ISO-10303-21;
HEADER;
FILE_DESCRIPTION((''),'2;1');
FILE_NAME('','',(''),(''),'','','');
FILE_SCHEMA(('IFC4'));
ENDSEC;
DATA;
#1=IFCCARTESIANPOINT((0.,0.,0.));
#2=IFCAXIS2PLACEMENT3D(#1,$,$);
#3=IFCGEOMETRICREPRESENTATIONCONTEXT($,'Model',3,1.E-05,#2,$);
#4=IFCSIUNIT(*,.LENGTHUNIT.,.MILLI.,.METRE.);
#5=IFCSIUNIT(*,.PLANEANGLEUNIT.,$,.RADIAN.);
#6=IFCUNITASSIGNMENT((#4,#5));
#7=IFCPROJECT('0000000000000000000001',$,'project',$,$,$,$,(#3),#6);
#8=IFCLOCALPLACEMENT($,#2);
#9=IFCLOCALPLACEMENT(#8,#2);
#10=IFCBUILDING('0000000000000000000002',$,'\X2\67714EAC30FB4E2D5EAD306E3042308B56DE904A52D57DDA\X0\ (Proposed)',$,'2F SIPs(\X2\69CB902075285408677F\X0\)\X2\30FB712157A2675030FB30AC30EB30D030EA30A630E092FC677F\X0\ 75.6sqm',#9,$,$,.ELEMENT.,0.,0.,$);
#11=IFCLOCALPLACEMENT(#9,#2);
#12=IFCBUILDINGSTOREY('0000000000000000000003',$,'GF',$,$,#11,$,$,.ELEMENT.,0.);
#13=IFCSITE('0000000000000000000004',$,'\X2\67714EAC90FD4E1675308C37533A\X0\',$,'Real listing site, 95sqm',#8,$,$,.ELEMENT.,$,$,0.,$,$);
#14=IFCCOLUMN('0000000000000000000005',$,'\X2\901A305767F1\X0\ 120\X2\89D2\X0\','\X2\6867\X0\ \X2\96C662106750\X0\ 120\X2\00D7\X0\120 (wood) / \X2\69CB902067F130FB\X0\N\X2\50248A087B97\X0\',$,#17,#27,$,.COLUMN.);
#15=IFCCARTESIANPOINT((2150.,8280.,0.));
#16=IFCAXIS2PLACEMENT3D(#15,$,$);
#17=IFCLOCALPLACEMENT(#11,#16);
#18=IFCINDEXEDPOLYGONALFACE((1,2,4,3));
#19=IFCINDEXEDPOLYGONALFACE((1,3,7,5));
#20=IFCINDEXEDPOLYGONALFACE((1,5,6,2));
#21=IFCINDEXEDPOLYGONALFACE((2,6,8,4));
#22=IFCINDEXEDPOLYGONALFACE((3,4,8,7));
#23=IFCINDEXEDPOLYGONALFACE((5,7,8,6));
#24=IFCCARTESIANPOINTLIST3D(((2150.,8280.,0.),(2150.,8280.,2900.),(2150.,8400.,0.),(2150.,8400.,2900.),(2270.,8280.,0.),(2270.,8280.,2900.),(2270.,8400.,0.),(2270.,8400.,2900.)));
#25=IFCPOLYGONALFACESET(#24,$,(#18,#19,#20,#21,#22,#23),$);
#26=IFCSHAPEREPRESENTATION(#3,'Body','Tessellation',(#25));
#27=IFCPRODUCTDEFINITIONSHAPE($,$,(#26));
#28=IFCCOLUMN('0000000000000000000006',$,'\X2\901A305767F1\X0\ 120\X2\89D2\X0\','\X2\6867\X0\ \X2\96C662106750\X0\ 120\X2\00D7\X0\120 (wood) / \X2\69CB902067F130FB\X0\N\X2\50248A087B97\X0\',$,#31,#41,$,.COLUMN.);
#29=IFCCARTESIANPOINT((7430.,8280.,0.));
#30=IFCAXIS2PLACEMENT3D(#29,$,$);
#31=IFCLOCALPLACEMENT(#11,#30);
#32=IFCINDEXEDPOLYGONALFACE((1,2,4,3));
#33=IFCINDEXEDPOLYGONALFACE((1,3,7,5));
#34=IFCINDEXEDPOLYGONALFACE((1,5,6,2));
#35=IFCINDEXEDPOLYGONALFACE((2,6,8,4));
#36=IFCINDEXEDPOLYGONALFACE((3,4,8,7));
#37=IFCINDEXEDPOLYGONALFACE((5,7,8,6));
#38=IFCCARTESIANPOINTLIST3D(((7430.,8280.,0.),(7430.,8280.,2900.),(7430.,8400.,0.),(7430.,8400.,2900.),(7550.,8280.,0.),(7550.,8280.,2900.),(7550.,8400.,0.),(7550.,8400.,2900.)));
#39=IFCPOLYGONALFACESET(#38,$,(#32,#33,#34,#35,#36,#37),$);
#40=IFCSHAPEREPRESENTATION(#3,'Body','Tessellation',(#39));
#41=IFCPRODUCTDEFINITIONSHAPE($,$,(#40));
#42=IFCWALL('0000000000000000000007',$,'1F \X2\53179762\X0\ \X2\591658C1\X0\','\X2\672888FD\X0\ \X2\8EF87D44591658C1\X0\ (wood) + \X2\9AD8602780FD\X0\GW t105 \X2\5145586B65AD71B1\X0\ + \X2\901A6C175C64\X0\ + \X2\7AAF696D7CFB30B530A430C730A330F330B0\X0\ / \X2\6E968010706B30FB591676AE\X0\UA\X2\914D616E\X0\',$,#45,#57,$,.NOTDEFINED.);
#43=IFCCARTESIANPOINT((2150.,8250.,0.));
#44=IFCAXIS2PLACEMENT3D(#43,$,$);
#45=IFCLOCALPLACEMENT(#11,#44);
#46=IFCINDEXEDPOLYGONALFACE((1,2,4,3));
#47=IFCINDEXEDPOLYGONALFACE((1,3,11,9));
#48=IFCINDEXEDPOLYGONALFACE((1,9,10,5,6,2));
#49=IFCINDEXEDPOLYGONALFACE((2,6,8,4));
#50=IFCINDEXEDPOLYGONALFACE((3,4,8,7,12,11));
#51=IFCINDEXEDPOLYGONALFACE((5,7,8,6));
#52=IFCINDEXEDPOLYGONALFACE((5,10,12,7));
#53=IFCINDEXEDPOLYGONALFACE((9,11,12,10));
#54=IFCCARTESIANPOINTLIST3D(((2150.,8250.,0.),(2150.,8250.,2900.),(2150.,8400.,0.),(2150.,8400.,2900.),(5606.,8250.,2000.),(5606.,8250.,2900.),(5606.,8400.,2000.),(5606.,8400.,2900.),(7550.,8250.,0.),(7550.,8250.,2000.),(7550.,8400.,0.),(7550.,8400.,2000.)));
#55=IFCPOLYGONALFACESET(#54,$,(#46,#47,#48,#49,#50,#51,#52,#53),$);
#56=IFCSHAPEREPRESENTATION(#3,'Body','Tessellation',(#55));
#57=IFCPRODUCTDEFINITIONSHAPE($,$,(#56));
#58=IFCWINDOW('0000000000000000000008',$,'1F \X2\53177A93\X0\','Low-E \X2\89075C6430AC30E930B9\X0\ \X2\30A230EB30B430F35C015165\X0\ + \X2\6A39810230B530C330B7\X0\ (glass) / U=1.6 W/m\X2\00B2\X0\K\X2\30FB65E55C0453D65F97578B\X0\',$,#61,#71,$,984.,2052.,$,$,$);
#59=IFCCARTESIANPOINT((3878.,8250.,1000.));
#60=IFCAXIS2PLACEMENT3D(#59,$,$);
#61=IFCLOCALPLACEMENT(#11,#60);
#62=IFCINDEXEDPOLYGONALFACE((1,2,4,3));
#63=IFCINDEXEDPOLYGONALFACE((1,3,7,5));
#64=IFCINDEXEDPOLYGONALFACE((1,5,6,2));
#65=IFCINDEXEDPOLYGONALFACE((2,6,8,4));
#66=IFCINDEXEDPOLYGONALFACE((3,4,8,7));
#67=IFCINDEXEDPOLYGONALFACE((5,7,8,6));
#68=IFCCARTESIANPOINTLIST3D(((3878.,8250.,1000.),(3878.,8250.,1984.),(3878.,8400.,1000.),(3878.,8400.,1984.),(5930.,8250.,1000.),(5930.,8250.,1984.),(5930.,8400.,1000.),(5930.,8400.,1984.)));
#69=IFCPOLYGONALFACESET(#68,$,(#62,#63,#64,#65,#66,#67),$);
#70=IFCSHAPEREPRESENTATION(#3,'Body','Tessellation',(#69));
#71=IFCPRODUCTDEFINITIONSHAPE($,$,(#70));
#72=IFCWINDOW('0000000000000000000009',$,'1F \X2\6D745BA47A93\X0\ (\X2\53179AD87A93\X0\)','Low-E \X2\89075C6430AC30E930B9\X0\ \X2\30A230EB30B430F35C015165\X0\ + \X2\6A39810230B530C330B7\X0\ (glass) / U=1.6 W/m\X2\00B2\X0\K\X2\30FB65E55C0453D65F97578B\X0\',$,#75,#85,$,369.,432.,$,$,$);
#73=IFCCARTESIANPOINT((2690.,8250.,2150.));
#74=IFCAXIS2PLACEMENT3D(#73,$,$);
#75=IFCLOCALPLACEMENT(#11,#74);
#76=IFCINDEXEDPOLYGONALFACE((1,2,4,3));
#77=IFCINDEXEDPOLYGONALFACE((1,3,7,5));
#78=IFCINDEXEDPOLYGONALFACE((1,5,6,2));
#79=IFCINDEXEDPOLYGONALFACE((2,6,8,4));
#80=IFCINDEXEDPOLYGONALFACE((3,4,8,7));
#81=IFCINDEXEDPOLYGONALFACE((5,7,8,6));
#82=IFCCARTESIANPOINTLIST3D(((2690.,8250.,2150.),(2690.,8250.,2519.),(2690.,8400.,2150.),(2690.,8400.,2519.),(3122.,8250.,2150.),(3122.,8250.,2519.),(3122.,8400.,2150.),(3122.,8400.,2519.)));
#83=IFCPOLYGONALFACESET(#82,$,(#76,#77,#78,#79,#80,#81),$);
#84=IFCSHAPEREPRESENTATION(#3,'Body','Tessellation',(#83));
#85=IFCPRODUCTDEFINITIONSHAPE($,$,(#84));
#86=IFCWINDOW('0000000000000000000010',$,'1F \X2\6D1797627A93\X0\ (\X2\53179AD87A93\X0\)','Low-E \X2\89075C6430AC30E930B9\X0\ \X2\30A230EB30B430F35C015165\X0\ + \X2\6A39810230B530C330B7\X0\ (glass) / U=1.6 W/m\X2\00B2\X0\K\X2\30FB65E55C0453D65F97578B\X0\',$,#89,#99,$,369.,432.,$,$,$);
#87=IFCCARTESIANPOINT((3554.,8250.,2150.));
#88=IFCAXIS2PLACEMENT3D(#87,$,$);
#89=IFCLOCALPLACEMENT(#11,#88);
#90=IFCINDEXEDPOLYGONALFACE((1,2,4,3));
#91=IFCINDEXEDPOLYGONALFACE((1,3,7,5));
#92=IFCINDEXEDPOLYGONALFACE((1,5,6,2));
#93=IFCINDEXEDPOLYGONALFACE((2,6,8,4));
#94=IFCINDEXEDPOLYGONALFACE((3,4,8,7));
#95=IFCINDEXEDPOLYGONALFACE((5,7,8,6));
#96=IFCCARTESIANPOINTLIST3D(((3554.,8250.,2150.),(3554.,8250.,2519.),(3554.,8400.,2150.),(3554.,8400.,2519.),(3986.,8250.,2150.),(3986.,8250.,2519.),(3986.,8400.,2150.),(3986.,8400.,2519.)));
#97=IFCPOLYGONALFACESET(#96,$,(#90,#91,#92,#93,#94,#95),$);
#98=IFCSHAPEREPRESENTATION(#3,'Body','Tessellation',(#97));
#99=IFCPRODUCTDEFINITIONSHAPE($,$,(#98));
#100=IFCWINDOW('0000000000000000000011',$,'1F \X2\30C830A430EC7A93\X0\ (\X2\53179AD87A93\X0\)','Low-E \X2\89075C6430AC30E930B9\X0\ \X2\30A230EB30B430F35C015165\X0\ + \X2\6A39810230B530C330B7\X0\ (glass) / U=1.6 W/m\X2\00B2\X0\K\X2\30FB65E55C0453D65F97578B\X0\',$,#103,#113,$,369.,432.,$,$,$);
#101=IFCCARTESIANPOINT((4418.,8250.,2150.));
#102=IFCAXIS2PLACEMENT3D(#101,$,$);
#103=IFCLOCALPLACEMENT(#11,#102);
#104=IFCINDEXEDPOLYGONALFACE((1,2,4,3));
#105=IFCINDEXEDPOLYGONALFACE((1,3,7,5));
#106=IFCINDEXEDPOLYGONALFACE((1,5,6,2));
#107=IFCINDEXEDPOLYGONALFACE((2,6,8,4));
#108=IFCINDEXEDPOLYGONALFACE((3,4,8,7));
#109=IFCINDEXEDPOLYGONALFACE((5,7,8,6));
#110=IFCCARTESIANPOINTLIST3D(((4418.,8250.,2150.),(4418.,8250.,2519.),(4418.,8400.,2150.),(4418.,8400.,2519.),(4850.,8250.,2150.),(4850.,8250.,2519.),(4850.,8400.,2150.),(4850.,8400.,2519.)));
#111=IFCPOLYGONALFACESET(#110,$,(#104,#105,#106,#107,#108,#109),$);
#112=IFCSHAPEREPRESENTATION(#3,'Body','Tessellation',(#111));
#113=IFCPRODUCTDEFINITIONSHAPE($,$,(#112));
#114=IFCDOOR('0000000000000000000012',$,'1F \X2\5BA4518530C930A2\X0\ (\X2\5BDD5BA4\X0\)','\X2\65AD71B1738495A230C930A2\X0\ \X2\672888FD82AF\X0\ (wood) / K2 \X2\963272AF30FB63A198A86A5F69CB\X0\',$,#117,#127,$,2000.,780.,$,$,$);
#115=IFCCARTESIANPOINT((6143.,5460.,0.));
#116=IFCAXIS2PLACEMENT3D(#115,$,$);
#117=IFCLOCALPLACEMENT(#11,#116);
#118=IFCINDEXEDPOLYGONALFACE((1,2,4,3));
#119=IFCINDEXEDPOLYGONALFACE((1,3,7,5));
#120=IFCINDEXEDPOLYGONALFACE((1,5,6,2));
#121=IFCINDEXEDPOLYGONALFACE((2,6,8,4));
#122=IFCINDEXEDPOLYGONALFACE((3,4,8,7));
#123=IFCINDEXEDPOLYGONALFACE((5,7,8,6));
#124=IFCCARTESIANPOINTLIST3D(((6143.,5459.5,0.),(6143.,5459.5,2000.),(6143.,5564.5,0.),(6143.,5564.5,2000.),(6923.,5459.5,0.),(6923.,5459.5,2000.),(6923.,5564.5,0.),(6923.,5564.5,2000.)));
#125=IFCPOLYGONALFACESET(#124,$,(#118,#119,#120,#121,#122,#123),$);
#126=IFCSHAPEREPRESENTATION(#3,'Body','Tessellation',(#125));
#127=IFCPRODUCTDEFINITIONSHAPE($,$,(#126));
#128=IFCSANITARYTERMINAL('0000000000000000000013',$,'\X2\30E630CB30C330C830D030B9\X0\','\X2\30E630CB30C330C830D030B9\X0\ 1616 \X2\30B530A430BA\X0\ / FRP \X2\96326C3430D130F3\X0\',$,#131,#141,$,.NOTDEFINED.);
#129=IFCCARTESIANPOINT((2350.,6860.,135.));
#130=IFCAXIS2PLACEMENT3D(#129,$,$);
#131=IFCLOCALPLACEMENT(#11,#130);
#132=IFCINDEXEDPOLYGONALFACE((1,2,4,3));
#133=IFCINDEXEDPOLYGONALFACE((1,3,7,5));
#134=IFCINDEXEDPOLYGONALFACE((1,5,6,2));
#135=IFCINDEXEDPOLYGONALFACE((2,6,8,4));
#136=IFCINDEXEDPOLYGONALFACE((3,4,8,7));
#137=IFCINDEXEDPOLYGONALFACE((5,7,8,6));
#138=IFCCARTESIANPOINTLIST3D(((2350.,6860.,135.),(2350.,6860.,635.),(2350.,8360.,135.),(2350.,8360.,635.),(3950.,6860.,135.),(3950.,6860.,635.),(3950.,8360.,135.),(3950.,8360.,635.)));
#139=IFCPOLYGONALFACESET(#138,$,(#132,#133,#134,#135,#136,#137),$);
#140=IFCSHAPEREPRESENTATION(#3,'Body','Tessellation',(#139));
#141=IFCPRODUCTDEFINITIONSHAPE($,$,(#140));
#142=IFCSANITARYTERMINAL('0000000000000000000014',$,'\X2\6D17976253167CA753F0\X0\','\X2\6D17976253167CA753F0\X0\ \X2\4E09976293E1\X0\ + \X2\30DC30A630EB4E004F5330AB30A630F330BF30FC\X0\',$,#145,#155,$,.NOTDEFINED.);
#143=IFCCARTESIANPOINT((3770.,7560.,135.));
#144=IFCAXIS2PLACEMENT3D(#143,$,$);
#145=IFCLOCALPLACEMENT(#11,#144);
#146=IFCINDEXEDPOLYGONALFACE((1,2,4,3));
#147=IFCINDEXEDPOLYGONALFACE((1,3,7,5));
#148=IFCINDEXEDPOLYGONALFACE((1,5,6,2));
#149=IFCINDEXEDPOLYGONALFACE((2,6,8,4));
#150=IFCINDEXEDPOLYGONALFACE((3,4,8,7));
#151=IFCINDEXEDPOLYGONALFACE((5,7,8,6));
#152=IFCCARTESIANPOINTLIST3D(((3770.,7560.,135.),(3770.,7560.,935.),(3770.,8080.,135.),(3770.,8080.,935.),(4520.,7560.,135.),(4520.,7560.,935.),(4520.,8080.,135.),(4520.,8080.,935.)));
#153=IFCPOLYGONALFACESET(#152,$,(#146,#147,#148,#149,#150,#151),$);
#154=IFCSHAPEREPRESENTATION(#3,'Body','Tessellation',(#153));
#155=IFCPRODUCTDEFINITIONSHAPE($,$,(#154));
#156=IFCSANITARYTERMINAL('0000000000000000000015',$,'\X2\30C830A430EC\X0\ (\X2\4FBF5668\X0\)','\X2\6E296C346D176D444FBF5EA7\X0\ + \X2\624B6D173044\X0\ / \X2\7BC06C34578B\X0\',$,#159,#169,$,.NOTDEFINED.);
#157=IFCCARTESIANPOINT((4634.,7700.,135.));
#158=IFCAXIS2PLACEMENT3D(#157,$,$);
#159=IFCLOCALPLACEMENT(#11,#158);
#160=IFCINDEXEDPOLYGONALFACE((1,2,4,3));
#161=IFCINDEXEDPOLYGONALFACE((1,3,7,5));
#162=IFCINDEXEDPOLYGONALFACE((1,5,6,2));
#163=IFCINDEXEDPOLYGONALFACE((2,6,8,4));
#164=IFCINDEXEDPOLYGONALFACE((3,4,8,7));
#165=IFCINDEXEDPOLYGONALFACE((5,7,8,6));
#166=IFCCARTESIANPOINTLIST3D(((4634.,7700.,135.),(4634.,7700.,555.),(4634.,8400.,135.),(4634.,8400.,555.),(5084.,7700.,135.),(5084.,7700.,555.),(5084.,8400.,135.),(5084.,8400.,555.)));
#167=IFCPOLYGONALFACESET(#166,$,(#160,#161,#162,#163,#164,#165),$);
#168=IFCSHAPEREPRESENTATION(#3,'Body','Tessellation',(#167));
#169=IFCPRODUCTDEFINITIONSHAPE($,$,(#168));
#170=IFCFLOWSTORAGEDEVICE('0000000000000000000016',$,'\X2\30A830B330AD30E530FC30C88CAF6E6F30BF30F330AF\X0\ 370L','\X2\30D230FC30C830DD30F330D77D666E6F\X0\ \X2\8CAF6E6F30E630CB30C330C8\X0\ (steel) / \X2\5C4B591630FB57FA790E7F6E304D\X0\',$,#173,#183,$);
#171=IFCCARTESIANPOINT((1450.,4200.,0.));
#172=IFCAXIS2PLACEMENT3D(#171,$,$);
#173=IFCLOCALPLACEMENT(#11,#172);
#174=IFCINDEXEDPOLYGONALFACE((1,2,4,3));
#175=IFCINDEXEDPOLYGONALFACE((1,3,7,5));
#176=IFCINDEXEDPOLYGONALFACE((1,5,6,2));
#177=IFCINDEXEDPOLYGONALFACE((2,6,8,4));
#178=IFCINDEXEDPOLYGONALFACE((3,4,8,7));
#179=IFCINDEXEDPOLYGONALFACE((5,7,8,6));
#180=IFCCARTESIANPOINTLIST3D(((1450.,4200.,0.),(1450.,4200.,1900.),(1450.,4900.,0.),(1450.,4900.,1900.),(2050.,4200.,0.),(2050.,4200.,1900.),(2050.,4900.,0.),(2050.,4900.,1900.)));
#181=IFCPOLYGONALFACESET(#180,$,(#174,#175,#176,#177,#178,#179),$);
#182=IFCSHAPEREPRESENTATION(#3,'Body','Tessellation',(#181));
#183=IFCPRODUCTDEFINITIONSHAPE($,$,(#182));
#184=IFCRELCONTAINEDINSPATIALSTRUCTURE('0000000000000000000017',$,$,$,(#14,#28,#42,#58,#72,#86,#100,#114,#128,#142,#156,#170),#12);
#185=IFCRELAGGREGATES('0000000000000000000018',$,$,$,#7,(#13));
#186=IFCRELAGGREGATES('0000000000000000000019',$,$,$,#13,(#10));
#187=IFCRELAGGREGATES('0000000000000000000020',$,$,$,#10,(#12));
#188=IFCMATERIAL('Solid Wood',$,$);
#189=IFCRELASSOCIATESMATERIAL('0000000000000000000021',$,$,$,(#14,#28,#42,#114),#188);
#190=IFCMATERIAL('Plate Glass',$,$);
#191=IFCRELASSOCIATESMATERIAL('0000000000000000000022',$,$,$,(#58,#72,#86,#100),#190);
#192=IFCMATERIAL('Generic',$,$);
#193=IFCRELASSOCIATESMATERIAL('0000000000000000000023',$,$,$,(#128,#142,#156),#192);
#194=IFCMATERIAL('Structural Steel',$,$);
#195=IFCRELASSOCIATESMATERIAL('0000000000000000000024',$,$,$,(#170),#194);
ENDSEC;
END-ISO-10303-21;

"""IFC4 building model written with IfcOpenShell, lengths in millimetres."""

from ifc_helpers import new_model, si_unit, frame, frame_2d, origin, place, context, project, spatial, rectangle, extrude, material, element, fill, save


model = new_model("IFC4")

# Units and contexts
model_context = context("Model", 3, precision=1e-05, world=origin())
ifc_project = project(units=[si_unit("LENGTHUNIT", "METRE", prefix="MILLI"), si_unit("PLANEANGLEUNIT", "RADIAN")], contexts=[model_context])

# Site, building, storey
site_placement = place(None, origin())
site = spatial("IfcSite", under=ifc_project, at=site_placement, Name="東京都世田谷区", ObjectType="Real listing site, 95sqm", CompositionType="ELEMENT", RefElevation=0.0)
building_placement = place(site_placement, origin())
building = spatial("IfcBuilding", under=site, at=building_placement, Name="東京・中庭のある回遊動線 (Proposed)", ObjectType="2F SIPs(構造用合板)・無垢材・ガルバリウム鋼板 75.6sqm", CompositionType="ELEMENT", ElevationOfRefHeight=0.0, ElevationOfTerrain=0.0)
storey_placement = place(building_placement, origin())
storey = spatial("IfcBuildingStorey", under=building, at=storey_placement, Name="GF", CompositionType="ELEMENT", Elevation=0.0)

# Columns
ifc_material_1 = material(Name="Solid Wood")
column_1_placement = place(storey_placement, frame((2150.0, 8280.0, 0.0)))
element("IfcColumn", 1, at=column_1_placement, inside=storey, material=ifc_material_1, Name="通し柱 120角", Description="桧 集成材 120×120 (wood) / 構造柱・N値計算", PredefinedType="COLUMN", context=model_context, shape_type="SweptSolid", body=[
    extrude(rectangle(XDim=120.0, YDim=120.0, at=frame_2d((60.0, 60.0))), frame((2150.0, 8280.0, 0.0)), (0.0, 0.0, 1.0), 2900.0),
])
column_2_placement = place(storey_placement, frame((7430.0, 8280.0, 0.0)))
element("IfcColumn", 2, at=column_2_placement, inside=storey, material=ifc_material_1, Name="通し柱 120角", Description="桧 集成材 120×120 (wood) / 構造柱・N値計算", PredefinedType="COLUMN", context=model_context, shape_type="SweptSolid", body=[
    extrude(rectangle(XDim=120.0, YDim=120.0, at=frame_2d((60.0, 60.0))), frame((7430.0, 8280.0, 0.0)), (0.0, 0.0, 1.0), 2900.0),
])

# Wall, openings, windows
wall_1_placement = place(storey_placement, frame((2150.0, 8250.0, 0.0)))
wall_1 = element("IfcWall", 3, at=wall_1_placement, inside=storey, material=ifc_material_1, Name="1F 北面 外壁", Description="木製 軸組外壁 (wood) + 高性能GW t105 充填断熱 + 通気層 + 窯業系サイディング / 準耐火・外皮UA配慮", PredefinedType="NOTDEFINED", context=model_context, shape_type="SweptSolid", body=[
    extrude(rectangle(XDim=5400.0, YDim=150.0, at=frame_2d((2700.0, 75.0))), frame((2150.0, 8250.0, 0.0)), (0.0, 0.0, 1.0), 2900.0),
])
opening_1_placement = place(storey_placement, frame((3878.0, 8250.0, 1000.0)))
opening_1 = element("IfcOpeningElement", 4, at=opening_1_placement, cuts=wall_1, PredefinedType="NOTDEFINED", context=model_context, shape_type="SweptSolid", body=[
    extrude(rectangle(XDim=2052.0, YDim=150.0, at=frame_2d((1026.0, 75.0))), frame((3878.0, 8250.0, 1000.0)), (0.0, 0.0, 1.0), 984.0),
])
opening_2_placement = place(storey_placement, frame((2690.0, 8250.0, 2150.0)))
opening_2 = element("IfcOpeningElement", 5, at=opening_2_placement, cuts=wall_1, PredefinedType="NOTDEFINED", context=model_context, shape_type="SweptSolid", body=[
    extrude(rectangle(XDim=432.0, YDim=150.0, at=frame_2d((216.0, 75.0))), frame((2690.0, 8250.0, 2150.0)), (0.0, 0.0, 1.0), 369.0),
])
opening_3_placement = place(storey_placement, frame((3554.0, 8250.0, 2150.0)))
opening_3 = element("IfcOpeningElement", 6, at=opening_3_placement, cuts=wall_1, PredefinedType="NOTDEFINED", context=model_context, shape_type="SweptSolid", body=[
    extrude(rectangle(XDim=432.0, YDim=150.0, at=frame_2d((216.0, 75.0))), frame((3554.0, 8250.0, 2150.0)), (0.0, 0.0, 1.0), 369.0),
])
opening_4_placement = place(storey_placement, frame((4418.0, 8250.0, 2150.0)))
opening_4 = element("IfcOpeningElement", 7, at=opening_4_placement, cuts=wall_1, PredefinedType="NOTDEFINED", context=model_context, shape_type="SweptSolid", body=[
    extrude(rectangle(XDim=432.0, YDim=150.0, at=frame_2d((216.0, 75.0))), frame((4418.0, 8250.0, 2150.0)), (0.0, 0.0, 1.0), 369.0),
])
ifc_material_2 = material(Name="Plate Glass")
window_1_placement = place(storey_placement, frame((3878.0, 8250.0, 1000.0)))
window_1 = element("IfcWindow", 8, at=window_1_placement, inside=storey, material=ifc_material_2, Name="1F 北窓", Description="Low-E 複層ガラス アルゴン封入 + 樹脂サッシ (glass) / U=1.6 W/m²K・日射取得型", OverallHeight=984.0, OverallWidth=2052.0, context=model_context, shape_type="SweptSolid", body=[
    extrude(rectangle(XDim=2052.0, YDim=150.0, at=frame_2d((1026.0, 75.0))), frame((3878.0, 8250.0, 1000.0)), (0.0, 0.0, 1.0), 984.0),
])
fill(opening_1, window_1)
window_2_placement = place(storey_placement, frame((2690.0, 8250.0, 2150.0)))
window_2 = element("IfcWindow", 9, at=window_2_placement, inside=storey, material=ifc_material_2, Name="1F 浴室窓 (北高窓)", Description="Low-E 複層ガラス アルゴン封入 + 樹脂サッシ (glass) / U=1.6 W/m²K・日射取得型", OverallHeight=369.0, OverallWidth=432.0, context=model_context, shape_type="SweptSolid", body=[
    extrude(rectangle(XDim=432.0, YDim=150.0, at=frame_2d((216.0, 75.0))), frame((2690.0, 8250.0, 2150.0)), (0.0, 0.0, 1.0), 369.0),
])
fill(opening_2, window_2)
window_3_placement = place(storey_placement, frame((3554.0, 8250.0, 2150.0)))
window_3 = element("IfcWindow", 10, at=window_3_placement, inside=storey, material=ifc_material_2, Name="1F 洗面窓 (北高窓)", Description="Low-E 複層ガラス アルゴン封入 + 樹脂サッシ (glass) / U=1.6 W/m²K・日射取得型", OverallHeight=369.0, OverallWidth=432.0, context=model_context, shape_type="SweptSolid", body=[
    extrude(rectangle(XDim=432.0, YDim=150.0, at=frame_2d((216.0, 75.0))), frame((3554.0, 8250.0, 2150.0)), (0.0, 0.0, 1.0), 369.0),
])
fill(opening_3, window_3)
window_4_placement = place(storey_placement, frame((4418.0, 8250.0, 2150.0)))
window_4 = element("IfcWindow", 11, at=window_4_placement, inside=storey, material=ifc_material_2, Name="1F トイレ窓 (北高窓)", Description="Low-E 複層ガラス アルゴン封入 + 樹脂サッシ (glass) / U=1.6 W/m²K・日射取得型", OverallHeight=369.0, OverallWidth=432.0, context=model_context, shape_type="SweptSolid", body=[
    extrude(rectangle(XDim=432.0, YDim=150.0, at=frame_2d((216.0, 75.0))), frame((4418.0, 8250.0, 2150.0)), (0.0, 0.0, 1.0), 369.0),
])
fill(opening_4, window_4)

# Door
door_1_placement = place(storey_placement, frame((6143.0, 5460.0, 0.0)))
element("IfcDoor", 12, at=door_1_placement, inside=storey, material=ifc_material_1, Name="1F 室内ドア (寝室)", Description="断熱玄関ドア 木製芯 (wood) / K2 防犯・採風機構", OverallHeight=2000.0, OverallWidth=780.0, context=model_context, shape_type="SweptSolid", body=[
    extrude(rectangle(XDim=780.0, YDim=105.0, at=frame_2d((390.0, 52.0))), frame((6143.0, 5460.0, 0.0)), (0.0, 0.0, 1.0), 2000.0),
])

# Sanitary terminals
ifc_material_3 = material(Name="Generic")
sanitary_terminal_1_placement = place(storey_placement, frame((2350.0, 6860.0, 135.0)))
element("IfcSanitaryTerminal", 13, at=sanitary_terminal_1_placement, inside=storey, material=ifc_material_3, Name="ユニットバス", Description="ユニットバス 1616 サイズ / FRP 防水パン", PredefinedType="NOTDEFINED", context=model_context, shape_type="SweptSolid", body=[
    extrude(rectangle(XDim=1600.0, YDim=1500.0, at=frame_2d((800.0, 750.0))), frame((2350.0, 6860.0, 135.0)), (0.0, 0.0, 1.0), 500.0),
])
sanitary_terminal_2_placement = place(storey_placement, frame((3770.0, 7560.0, 135.0)))
element("IfcSanitaryTerminal", 14, at=sanitary_terminal_2_placement, inside=storey, material=ifc_material_3, Name="洗面化粧台", Description="洗面化粧台 三面鏡 + ボウル一体カウンター", PredefinedType="NOTDEFINED", context=model_context, shape_type="SweptSolid", body=[
    extrude(rectangle(XDim=750.0, YDim=520.0, at=frame_2d((375.0, 260.0))), frame((3770.0, 7560.0, 135.0)), (0.0, 0.0, 1.0), 800.0),
])
sanitary_terminal_3_placement = place(storey_placement, frame((4634.0, 7700.0, 135.0)))
element("IfcSanitaryTerminal", 15, at=sanitary_terminal_3_placement, inside=storey, material=ifc_material_3, Name="トイレ (便器)", Description="温水洗浄便座 + 手洗い / 節水型", PredefinedType="NOTDEFINED", context=model_context, shape_type="SweptSolid", body=[
    extrude(rectangle(XDim=450.0, YDim=700.0, at=frame_2d((225.0, 350.0))), frame((4634.0, 7700.0, 135.0)), (0.0, 0.0, 1.0), 420.0),
])

# Flow storage device
ifc_material_4 = material(Name="Structural Steel")
flow_storage_device_placement = place(storey_placement, frame((1450.0, 4200.0, 0.0)))
element("IfcFlowStorageDevice", 16, at=flow_storage_device_placement, inside=storey, material=ifc_material_4, Name="エコキュート貯湯タンク 370L", Description="ヒートポンプ給湯 貯湯ユニット (steel) / 屋外・基礎置き", context=model_context, shape_type="SweptSolid", body=[
    extrude(rectangle(XDim=600.0, YDim=700.0, at=frame_2d((300.0, 350.0))), frame((1450.0, 4200.0, 0.0)), (0.0, 0.0, 1.0), 1900.0),
])

save(model, "model.ifc")
